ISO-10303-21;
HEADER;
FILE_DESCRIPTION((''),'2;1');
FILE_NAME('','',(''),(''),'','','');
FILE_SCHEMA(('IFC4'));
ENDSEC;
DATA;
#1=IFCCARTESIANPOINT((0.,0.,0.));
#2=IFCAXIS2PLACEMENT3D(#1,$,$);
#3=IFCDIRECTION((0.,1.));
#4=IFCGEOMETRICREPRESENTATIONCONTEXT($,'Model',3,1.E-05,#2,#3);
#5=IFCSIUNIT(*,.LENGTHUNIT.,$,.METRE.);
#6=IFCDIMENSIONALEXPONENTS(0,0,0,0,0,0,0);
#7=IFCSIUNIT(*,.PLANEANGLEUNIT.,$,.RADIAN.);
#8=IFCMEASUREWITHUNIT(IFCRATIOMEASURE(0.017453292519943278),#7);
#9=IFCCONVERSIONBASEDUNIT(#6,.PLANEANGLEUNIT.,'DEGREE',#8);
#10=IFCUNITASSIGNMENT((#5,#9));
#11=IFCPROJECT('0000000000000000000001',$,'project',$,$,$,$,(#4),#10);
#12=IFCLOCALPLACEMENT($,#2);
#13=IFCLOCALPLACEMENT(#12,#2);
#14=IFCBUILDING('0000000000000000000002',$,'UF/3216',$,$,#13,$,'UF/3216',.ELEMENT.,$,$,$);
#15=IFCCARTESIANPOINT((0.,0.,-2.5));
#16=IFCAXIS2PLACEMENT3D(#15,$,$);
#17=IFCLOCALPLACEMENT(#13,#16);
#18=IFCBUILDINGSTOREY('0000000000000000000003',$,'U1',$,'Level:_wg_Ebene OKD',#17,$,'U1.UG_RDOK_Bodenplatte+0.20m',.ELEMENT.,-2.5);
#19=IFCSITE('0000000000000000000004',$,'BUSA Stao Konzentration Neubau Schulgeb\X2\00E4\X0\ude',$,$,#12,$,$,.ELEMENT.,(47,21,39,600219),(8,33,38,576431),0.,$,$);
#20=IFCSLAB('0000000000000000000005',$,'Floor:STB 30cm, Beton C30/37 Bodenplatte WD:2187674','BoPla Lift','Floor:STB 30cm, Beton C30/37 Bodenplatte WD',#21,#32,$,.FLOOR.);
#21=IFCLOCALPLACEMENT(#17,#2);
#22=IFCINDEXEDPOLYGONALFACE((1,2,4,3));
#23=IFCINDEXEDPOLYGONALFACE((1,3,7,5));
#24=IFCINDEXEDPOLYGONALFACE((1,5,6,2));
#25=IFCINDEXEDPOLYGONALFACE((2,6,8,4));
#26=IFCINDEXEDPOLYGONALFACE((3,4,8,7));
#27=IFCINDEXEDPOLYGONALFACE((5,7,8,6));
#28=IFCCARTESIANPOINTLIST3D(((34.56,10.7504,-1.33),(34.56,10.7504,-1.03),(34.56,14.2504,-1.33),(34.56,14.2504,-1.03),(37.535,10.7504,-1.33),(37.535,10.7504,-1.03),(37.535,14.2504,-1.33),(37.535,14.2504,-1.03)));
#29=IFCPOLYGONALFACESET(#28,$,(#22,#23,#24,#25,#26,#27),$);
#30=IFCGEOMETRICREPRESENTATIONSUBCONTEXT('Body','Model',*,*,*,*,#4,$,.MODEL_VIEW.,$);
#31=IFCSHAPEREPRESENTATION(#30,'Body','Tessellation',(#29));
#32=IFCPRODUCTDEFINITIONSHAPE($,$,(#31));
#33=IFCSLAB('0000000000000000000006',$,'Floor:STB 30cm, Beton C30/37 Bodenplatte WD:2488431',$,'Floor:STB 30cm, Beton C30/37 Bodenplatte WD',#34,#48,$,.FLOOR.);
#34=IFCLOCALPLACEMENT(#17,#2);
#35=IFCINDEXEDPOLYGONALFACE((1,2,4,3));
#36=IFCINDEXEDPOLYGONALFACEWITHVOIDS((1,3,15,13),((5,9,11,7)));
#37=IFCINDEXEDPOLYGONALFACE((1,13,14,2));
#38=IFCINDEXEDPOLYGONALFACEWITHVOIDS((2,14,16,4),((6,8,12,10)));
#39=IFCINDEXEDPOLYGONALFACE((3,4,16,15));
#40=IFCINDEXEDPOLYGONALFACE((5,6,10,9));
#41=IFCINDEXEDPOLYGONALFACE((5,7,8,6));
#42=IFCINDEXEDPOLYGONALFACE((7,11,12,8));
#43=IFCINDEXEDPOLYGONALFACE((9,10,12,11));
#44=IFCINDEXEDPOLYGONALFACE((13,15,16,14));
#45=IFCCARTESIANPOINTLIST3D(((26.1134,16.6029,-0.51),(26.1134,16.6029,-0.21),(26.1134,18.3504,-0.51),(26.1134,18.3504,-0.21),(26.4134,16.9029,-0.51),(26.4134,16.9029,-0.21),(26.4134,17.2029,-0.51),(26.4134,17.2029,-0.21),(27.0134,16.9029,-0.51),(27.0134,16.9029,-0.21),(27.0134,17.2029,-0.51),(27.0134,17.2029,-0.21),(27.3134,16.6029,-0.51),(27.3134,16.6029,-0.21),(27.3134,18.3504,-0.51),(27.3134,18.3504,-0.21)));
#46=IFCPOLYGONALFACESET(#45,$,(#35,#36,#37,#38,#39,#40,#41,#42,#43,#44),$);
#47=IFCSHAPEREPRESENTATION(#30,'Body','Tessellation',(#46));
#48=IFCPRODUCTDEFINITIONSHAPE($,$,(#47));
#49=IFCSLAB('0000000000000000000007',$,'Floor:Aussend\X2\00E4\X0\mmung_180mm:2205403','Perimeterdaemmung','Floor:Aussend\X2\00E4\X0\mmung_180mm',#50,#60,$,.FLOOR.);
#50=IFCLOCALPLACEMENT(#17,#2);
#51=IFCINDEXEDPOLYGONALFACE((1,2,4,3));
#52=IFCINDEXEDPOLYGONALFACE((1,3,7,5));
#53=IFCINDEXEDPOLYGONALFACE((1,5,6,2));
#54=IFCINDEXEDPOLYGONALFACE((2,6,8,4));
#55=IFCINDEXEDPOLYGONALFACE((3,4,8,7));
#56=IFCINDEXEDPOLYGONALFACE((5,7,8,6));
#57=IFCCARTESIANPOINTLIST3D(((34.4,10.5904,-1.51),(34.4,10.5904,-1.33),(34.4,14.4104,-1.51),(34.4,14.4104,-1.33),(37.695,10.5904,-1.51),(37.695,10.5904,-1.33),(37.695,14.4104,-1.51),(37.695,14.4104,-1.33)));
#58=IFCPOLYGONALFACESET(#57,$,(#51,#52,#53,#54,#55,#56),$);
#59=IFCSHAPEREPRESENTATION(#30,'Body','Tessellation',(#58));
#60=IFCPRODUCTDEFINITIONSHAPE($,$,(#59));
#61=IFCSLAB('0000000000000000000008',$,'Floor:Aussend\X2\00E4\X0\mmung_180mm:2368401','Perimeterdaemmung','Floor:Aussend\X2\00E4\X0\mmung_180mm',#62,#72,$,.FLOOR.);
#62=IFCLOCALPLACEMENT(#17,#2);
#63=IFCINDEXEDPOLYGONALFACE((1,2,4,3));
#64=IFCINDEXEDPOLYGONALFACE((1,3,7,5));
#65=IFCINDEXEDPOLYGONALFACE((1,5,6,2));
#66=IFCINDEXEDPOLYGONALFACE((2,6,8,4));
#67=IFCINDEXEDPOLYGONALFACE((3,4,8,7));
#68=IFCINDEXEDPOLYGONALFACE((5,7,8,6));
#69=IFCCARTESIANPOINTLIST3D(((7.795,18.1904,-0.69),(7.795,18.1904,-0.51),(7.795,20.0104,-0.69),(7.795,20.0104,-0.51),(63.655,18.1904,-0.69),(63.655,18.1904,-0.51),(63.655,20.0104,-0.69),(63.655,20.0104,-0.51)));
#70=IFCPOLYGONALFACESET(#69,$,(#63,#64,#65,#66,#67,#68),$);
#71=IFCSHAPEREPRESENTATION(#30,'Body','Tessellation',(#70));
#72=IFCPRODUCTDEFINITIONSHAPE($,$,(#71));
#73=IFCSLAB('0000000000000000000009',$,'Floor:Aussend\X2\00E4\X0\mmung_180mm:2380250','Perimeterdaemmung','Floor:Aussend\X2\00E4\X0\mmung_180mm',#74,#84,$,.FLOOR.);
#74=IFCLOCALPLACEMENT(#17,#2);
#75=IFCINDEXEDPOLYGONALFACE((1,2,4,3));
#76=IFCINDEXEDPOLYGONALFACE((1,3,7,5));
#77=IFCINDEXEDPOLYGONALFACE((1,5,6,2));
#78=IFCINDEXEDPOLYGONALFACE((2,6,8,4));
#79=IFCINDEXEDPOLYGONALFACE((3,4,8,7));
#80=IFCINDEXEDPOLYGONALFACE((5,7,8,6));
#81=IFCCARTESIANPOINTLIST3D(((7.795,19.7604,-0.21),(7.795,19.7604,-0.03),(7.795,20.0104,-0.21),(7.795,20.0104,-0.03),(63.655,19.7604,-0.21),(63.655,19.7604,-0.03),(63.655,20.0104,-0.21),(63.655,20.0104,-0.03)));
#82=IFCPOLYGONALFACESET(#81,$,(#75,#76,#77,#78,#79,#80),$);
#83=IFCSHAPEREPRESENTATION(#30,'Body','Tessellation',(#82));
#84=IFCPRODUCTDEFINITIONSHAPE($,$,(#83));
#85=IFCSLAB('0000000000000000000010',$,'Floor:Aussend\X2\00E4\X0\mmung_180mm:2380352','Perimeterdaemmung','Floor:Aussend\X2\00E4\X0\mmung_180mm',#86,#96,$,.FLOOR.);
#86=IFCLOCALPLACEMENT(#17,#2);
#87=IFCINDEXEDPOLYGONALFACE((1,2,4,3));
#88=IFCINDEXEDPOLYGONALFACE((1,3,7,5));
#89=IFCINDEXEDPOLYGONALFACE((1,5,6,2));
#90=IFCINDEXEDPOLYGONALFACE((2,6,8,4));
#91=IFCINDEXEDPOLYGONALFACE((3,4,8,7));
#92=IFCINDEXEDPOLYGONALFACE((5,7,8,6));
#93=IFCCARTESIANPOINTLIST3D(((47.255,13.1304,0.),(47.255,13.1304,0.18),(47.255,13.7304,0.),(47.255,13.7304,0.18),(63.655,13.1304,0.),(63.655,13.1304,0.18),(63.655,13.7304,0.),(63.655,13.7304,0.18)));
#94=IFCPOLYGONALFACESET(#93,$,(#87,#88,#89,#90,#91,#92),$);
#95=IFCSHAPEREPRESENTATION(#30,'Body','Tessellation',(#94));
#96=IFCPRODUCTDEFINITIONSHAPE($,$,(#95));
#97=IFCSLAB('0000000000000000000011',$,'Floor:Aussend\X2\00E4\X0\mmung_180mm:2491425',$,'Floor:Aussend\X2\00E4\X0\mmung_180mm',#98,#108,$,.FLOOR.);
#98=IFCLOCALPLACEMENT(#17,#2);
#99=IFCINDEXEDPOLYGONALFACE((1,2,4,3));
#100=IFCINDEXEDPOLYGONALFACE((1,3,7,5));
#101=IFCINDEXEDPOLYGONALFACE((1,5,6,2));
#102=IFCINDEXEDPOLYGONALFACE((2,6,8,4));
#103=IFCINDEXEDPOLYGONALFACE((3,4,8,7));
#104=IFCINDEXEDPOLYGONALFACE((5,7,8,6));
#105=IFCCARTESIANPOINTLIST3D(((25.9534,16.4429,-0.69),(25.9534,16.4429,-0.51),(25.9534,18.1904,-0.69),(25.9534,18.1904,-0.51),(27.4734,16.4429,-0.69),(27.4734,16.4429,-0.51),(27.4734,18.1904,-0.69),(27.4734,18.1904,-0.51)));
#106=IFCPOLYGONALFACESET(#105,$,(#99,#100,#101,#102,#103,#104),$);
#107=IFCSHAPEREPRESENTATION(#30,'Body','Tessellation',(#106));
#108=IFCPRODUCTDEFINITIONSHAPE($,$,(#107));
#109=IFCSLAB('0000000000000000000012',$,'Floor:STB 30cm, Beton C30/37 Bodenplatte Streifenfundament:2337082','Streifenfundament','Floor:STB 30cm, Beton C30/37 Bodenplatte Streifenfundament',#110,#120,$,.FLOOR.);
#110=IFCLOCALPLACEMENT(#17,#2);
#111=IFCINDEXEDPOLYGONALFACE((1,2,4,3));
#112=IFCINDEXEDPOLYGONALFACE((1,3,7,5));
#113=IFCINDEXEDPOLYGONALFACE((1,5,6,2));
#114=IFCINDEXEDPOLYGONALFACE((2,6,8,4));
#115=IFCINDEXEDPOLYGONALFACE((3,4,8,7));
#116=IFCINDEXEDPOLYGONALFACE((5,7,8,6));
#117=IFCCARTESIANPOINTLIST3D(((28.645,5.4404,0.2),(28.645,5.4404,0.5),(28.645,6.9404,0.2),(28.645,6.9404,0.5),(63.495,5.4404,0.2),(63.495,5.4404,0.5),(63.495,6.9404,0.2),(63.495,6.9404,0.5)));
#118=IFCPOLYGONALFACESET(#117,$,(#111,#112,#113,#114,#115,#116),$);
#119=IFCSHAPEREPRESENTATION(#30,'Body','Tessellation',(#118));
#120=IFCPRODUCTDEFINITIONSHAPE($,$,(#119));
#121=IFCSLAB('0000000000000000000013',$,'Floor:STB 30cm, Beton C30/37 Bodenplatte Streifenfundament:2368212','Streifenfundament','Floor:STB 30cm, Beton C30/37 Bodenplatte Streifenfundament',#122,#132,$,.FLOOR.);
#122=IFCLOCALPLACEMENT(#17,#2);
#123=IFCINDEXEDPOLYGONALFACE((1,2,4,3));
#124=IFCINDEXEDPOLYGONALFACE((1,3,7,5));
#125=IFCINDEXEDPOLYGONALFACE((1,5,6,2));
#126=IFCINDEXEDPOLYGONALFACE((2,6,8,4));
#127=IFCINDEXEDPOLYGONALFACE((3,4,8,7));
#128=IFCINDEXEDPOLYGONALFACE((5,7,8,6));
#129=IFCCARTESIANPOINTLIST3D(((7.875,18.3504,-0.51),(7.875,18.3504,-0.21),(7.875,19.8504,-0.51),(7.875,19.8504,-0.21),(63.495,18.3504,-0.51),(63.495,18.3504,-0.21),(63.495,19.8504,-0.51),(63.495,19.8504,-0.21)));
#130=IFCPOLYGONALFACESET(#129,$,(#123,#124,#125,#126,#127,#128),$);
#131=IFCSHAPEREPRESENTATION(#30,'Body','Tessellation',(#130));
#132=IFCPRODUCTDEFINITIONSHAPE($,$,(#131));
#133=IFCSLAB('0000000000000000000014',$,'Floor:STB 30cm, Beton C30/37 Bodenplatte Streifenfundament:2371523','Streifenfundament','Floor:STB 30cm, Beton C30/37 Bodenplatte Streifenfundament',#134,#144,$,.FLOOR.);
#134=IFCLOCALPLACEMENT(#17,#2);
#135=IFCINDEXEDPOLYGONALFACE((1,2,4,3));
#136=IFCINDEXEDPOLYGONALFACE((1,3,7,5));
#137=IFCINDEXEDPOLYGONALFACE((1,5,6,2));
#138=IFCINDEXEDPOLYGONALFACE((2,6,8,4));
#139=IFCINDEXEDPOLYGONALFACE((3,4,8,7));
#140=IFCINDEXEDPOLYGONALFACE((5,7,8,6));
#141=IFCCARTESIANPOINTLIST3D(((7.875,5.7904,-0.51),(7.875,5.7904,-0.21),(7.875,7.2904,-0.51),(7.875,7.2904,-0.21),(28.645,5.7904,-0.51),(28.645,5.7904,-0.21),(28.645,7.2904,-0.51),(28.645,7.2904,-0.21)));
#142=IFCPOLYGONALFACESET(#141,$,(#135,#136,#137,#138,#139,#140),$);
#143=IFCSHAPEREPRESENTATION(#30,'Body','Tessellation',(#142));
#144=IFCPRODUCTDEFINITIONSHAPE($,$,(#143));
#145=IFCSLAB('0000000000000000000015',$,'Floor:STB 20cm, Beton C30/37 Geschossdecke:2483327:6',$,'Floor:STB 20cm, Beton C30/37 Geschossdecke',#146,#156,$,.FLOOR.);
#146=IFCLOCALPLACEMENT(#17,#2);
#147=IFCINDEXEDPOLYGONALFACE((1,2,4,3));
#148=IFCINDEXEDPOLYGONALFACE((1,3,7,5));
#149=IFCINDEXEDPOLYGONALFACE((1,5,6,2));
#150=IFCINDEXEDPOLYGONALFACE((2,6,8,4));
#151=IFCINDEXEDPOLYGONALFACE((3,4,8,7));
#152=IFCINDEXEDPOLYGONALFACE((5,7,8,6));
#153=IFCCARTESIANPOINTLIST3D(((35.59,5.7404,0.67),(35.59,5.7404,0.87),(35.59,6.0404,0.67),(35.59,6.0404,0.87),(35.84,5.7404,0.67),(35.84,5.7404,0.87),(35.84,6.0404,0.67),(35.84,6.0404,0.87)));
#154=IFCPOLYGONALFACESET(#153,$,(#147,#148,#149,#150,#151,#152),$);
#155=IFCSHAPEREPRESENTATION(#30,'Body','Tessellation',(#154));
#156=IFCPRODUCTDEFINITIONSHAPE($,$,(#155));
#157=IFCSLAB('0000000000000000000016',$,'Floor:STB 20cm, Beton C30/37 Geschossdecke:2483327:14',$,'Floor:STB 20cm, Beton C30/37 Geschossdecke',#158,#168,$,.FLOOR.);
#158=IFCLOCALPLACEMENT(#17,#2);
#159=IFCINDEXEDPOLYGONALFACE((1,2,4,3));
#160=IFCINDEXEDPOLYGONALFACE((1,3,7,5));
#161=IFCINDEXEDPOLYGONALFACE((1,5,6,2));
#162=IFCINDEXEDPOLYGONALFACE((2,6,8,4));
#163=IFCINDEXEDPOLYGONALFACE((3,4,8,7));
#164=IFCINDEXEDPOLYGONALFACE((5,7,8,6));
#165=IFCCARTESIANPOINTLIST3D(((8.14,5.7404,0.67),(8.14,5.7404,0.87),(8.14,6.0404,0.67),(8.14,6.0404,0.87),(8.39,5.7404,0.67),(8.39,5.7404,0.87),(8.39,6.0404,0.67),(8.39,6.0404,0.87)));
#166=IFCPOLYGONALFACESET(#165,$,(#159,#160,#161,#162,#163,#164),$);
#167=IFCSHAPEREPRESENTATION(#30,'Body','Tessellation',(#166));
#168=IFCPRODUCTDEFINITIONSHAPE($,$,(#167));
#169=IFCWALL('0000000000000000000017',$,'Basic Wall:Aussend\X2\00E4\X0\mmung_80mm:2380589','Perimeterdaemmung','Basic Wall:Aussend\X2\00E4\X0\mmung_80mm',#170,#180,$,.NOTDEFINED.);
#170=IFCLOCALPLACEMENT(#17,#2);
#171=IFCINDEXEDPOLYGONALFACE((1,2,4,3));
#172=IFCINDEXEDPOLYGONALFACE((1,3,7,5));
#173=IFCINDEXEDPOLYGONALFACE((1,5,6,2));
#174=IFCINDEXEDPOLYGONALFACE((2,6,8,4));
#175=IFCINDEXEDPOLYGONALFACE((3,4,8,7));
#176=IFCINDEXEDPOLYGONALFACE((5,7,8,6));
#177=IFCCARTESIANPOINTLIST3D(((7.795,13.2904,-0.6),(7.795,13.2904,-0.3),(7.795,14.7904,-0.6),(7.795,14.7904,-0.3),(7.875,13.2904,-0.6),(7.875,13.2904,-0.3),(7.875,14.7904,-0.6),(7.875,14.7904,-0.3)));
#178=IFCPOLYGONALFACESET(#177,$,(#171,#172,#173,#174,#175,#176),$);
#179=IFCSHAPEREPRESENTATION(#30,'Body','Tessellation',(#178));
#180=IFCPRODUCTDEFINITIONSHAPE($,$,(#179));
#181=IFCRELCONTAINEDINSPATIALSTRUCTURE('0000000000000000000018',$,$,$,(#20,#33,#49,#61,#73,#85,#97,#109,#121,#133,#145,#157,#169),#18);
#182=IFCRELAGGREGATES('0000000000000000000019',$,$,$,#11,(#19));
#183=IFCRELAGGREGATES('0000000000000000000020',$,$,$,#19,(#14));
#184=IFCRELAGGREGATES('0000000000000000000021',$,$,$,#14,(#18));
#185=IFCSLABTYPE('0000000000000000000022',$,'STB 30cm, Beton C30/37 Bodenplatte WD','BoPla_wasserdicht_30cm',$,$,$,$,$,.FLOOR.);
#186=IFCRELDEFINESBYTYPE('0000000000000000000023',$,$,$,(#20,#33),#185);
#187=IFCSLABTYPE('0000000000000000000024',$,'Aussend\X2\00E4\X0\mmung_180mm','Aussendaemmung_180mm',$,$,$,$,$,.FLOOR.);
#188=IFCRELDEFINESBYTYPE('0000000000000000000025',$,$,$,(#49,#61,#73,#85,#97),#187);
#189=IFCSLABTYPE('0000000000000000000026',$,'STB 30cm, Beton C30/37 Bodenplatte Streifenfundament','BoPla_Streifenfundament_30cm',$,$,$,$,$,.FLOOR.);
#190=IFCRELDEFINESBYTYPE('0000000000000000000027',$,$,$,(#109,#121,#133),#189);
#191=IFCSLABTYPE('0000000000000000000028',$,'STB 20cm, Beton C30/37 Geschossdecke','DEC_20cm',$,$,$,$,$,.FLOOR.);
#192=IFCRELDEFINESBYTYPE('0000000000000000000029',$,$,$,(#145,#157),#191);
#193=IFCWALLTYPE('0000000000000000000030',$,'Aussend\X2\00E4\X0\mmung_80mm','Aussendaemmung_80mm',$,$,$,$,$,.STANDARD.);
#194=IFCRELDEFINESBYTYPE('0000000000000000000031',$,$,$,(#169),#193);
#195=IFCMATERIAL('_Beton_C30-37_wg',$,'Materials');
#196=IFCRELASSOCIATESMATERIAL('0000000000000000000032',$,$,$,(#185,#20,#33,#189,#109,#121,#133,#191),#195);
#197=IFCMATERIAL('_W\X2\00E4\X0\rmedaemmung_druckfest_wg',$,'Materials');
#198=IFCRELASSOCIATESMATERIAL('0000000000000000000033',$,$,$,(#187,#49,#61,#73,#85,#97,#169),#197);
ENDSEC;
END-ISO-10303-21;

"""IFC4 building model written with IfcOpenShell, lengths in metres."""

from ifc_helpers import new_model, entity, si_unit, converted_unit, direction, frame, frame_2d, origin, place, context, subcontext, project, spatial, indexed_curve, rectangle, outline, extrude, material, type_object, element, save


model = new_model("IFC4")

# Units and contexts
model_context = context("Model", 3, precision=1e-05, world=origin(), true_north=direction((0.0, 1.0)))
body_context = subcontext(model_context, "Body", "Model", "MODEL_VIEW")
ifc_project = project(units=[si_unit("LENGTHUNIT", "METRE"), converted_unit("PLANEANGLEUNIT", "DEGREE", entity("IfcRatioMeasure", 0.017453292519943278), si_unit("PLANEANGLEUNIT", "RADIAN"), dimensions=[0, 0, 0, 0, 0, 0, 0])], contexts=[model_context])

# Site, building, storey
site_placement = place(None, origin())
site = spatial("IfcSite", under=ifc_project, at=site_placement, Name="BUSA Stao Konzentration Neubau Schulgebäude", CompositionType="ELEMENT", RefLatitude=(47, 21, 39, 600219), RefLongitude=(8, 33, 38, 576431), RefElevation=0.0)
building_placement = place(site_placement, origin())
building = spatial("IfcBuilding", under=site, at=building_placement, Name="UF/3216", LongName="UF/3216", CompositionType="ELEMENT")
storey_placement = place(building_placement, frame((0.0, 0.0, -2.5)))
storey = spatial("IfcBuildingStorey", under=building, at=storey_placement, Name="U1", ObjectType="Level:_wg_Ebene OKD", LongName="U1.UG_RDOK_Bodenplatte+0.20m", CompositionType="ELEMENT", Elevation=-2.5)

# Slabs
ifc_material_1 = material(Name="_Beton_C30-37_wg", Category="Materials")
slab_type_1 = type_object("IfcSlabType", Name="STB 30cm, Beton C30/37 Bodenplatte WD", Description="BoPla_wasserdicht_30cm", PredefinedType="FLOOR", material=ifc_material_1)
slab_1_placement = place(storey_placement, origin())
element("IfcSlab", 1, at=slab_1_placement, inside=storey, type_object=slab_type_1, material=ifc_material_1, Name="Floor:STB 30cm, Beton C30/37 Bodenplatte WD:2187674", Description="BoPla Lift", ObjectType="Floor:STB 30cm, Beton C30/37 Bodenplatte WD", PredefinedType="FLOOR", context=body_context, shape_type="SweptSolid", body=[
    extrude(outline(indexed_curve([(-1.75, -1.4875), (1.75, -1.4875), (1.75, 1.4875), (-1.75, 1.4875), (-1.75, -1.4875)], self_intersect=False)), frame((36.0475, 12.5004, -1.03), z_axis=(0.0, 0.0, -1.0), x_axis=(0.0, 1.0, 0.0)), (0.0, 0.0, 1.0), 0.3),
])
slab_2_placement = place(storey_placement, origin())
element("IfcSlab", 2, at=slab_2_placement, inside=storey, type_object=slab_type_1, material=ifc_material_1, Name="Floor:STB 30cm, Beton C30/37 Bodenplatte WD:2488431", ObjectType="Floor:STB 30cm, Beton C30/37 Bodenplatte WD", PredefinedType="FLOOR", context=body_context, shape_type="SweptSolid", body=[
    extrude(outline(indexed_curve([(-0.8737, -0.6), (0.8737, -0.6), (0.8737, 0.6), (-0.8737, 0.6), (-0.8737, -0.6)], self_intersect=False), holes=[indexed_curve([(0.2737, 0.3), (0.5737, 0.3), (0.5737, -0.3), (0.2737, -0.3), (0.2737, 0.3)], self_intersect=False)]), frame((26.7134, 17.4766, -0.51), z_axis=(0.0, 0.0, 1.0), x_axis=(0.0, -1.0, 0.0)), (0.0, 0.0, 1.0), 0.3),
])
ifc_material_2 = material(Name="_Wärmedaemmung_druckfest_wg", Category="Materials")
slab_type_2 = type_object("IfcSlabType", Name="Aussendämmung_180mm", Description="Aussendaemmung_180mm", PredefinedType="FLOOR", material=ifc_material_2)
slab_3_placement = place(storey_placement, origin())
element("IfcSlab", 3, at=slab_3_placement, inside=storey, type_object=slab_type_2, material=ifc_material_2, Name="Floor:Aussendämmung_180mm:2205403", Description="Perimeterdaemmung", ObjectType="Floor:Aussendämmung_180mm", PredefinedType="FLOOR", context=body_context, shape_type="SweptSolid", body=[
    extrude(outline(indexed_curve([(-1.91, -1.6475), (1.91, -1.6475), (1.91, 1.6475), (-1.91, 1.6475), (-1.91, -1.6475)], self_intersect=False)), frame((36.0475, 12.5004, -1.33), z_axis=(0.0, 0.0, -1.0), x_axis=(0.0, 1.0, 0.0)), (0.0, 0.0, 1.0), 0.18),
])
slab_4_placement = place(storey_placement, origin())
element("IfcSlab", 4, at=slab_4_placement, inside=storey, type_object=slab_type_2, material=ifc_material_2, Name="Floor:Aussendämmung_180mm:2368401", Description="Perimeterdaemmung", ObjectType="Floor:Aussendämmung_180mm", PredefinedType="FLOOR", context=body_context, shape_type="SweptSolid", body=[
    extrude(outline(indexed_curve([(-0.91, -27.93), (0.91, -27.93), (0.91, 27.93), (-0.91, 27.93), (-0.91, -27.93)], self_intersect=False)), frame((35.725, 19.1004, -0.51), z_axis=(0.0, 0.0, -1.0), x_axis=(0.0, 1.0, 0.0)), (0.0, 0.0, 1.0), 0.18),
])
slab_5_placement = place(storey_placement, origin())
element("IfcSlab", 5, at=slab_5_placement, inside=storey, type_object=slab_type_2, material=ifc_material_2, Name="Floor:Aussendämmung_180mm:2380250", Description="Perimeterdaemmung", ObjectType="Floor:Aussendämmung_180mm", PredefinedType="FLOOR", context=body_context, shape_type="SweptSolid", body=[
    extrude(outline(indexed_curve([(-0.125, -27.93), (0.125, -27.93), (0.125, 27.93), (-0.125, 27.93), (-0.125, -27.93)], self_intersect=False)), frame((35.725, 19.8854, -0.03), z_axis=(0.0, 0.0, -1.0), x_axis=(0.0, 1.0, 0.0)), (0.0, 0.0, 1.0), 0.18),
])
slab_6_placement = place(storey_placement, origin())
element("IfcSlab", 6, at=slab_6_placement, inside=storey, type_object=slab_type_2, material=ifc_material_2, Name="Floor:Aussendämmung_180mm:2380352", Description="Perimeterdaemmung", ObjectType="Floor:Aussendämmung_180mm", PredefinedType="FLOOR", context=body_context, shape_type="SweptSolid", body=[
    extrude(outline(indexed_curve([(-0.3, -8.2), (0.3, -8.2), (0.3, 8.2), (-0.3, 8.2), (-0.3, -8.2)], self_intersect=False)), frame((55.455, 13.4304, 0.18), z_axis=(0.0, 0.0, -1.0), x_axis=(0.0, 1.0, 0.0)), (0.0, 0.0, 1.0), 0.18),
])
slab_7_placement = place(storey_placement, origin())
element("IfcSlab", 7, at=slab_7_placement, inside=storey, type_object=slab_type_2, material=ifc_material_2, Name="Floor:Aussendämmung_180mm:2491425", ObjectType="Floor:Aussendämmung_180mm", PredefinedType="FLOOR", context=body_context, shape_type="SweptSolid", body=[
    extrude(outline(indexed_curve([(-0.8737, -0.76), (0.8737, -0.76), (0.8737, 0.76), (-0.8737, 0.76), (-0.8737, -0.76)], self_intersect=False)), frame((26.7134, 17.3166, -0.51), z_axis=(0.0, 0.0, -1.0), x_axis=(0.0, 1.0, 0.0)), (0.0, 0.0, 1.0), 0.18),
])
slab_type_3 = type_object("IfcSlabType", Name="STB 30cm, Beton C30/37 Bodenplatte Streifenfundament", Description="BoPla_Streifenfundament_30cm", PredefinedType="FLOOR", material=ifc_material_1)
slab_8_placement = place(storey_placement, origin())
element("IfcSlab", 8, at=slab_8_placement, inside=storey, type_object=slab_type_3, material=ifc_material_1, Name="Floor:STB 30cm, Beton C30/37 Bodenplatte Streifenfundament:2337082", Description="Streifenfundament", ObjectType="Floor:STB 30cm, Beton C30/37 Bodenplatte Streifenfundament", PredefinedType="FLOOR", context=body_context, shape_type="SweptSolid", body=[
    extrude(outline(indexed_curve([(-0.75, -17.425), (0.75, -17.425), (0.75, 17.425), (-0.75, 17.425), (-0.75, -17.425)], self_intersect=False)), frame((46.07, 6.1904, 0.5), z_axis=(0.0, 0.0, -1.0), x_axis=(0.0, 1.0, 0.0)), (0.0, 0.0, 1.0), 0.3),
])
slab_9_placement = place(storey_placement, origin())
element("IfcSlab", 9, at=slab_9_placement, inside=storey, type_object=slab_type_3, material=ifc_material_1, Name="Floor:STB 30cm, Beton C30/37 Bodenplatte Streifenfundament:2368212", Description="Streifenfundament", ObjectType="Floor:STB 30cm, Beton C30/37 Bodenplatte Streifenfundament", PredefinedType="FLOOR", context=body_context, shape_type="SweptSolid", body=[
    extrude(outline(indexed_curve([(-0.75, -27.81), (0.75, -27.81), (0.75, 27.81), (-0.75, 27.81), (-0.75, -27.81)], self_intersect=False)), frame((35.685, 19.1004, -0.21), z_axis=(0.0, 0.0, -1.0), x_axis=(0.0, 1.0, 0.0)), (0.0, 0.0, 1.0), 0.3),
])
slab_10_placement = place(storey_placement, origin())
element("IfcSlab", 10, at=slab_10_placement, inside=storey, type_object=slab_type_3, material=ifc_material_1, Name="Floor:STB 30cm, Beton C30/37 Bodenplatte Streifenfundament:2371523", Description="Streifenfundament", ObjectType="Floor:STB 30cm, Beton C30/37 Bodenplatte Streifenfundament", PredefinedType="FLOOR", context=body_context, shape_type="SweptSolid", body=[
    extrude(outline(indexed_curve([(-0.75, -10.385), (0.75, -10.385), (0.75, 10.385), (-0.75, 10.385), (-0.75, -10.385)], self_intersect=False)), frame((18.26, 6.5404, -0.21), z_axis=(0.0, 0.0, -1.0), x_axis=(0.0, 1.0, 0.0)), (0.0, 0.0, 1.0), 0.3),
])
slab_type_4 = type_object("IfcSlabType", Name="STB 20cm, Beton C30/37 Geschossdecke", Description="DEC_20cm", PredefinedType="FLOOR", material=ifc_material_1)
slab_11_placement = place(storey_placement, frame((8.14, 5.7404, 0.67)))
element("IfcSlab", 11, at=slab_11_placement, inside=storey, type_object=slab_type_4, Name="Floor:STB 20cm, Beton C30/37 Geschossdecke:2483327:6", ObjectType="Floor:STB 20cm, Beton C30/37 Geschossdecke", PredefinedType="FLOOR", context=body_context, shape_type="SweptSolid", body=[
    extrude(rectangle(XDim=0.3, YDim=0.25, at=frame_2d((0.0, 0.0), x_axis=(0.0, -1.0))), frame((27.575, 0.15, 0.2), z_axis=(0.0, 0.0, -1.0), x_axis=(-1.0, 0.0, 0.0)), (0.0, 0.0, 1.0), 0.2),
])
slab_12_placement = place(storey_placement, frame((8.14, 5.7404, 0.67)))
element("IfcSlab", 12, at=slab_12_placement, inside=storey, type_object=slab_type_4, Name="Floor:STB 20cm, Beton C30/37 Geschossdecke:2483327:14", ObjectType="Floor:STB 20cm, Beton C30/37 Geschossdecke", PredefinedType="FLOOR", context=body_context, shape_type="SweptSolid", body=[
    extrude(rectangle(XDim=0.3, YDim=0.25, at=frame_2d((27.45, 0.0), x_axis=(0.0, -1.0))), frame((27.575, 0.15, 0.2), z_axis=(0.0, 0.0, -1.0), x_axis=(-1.0, 0.0, 0.0)), (0.0, 0.0, 1.0), 0.2),
])

# Wall
wall_type = type_object("IfcWallType", Name="Aussendämmung_80mm", Description="Aussendaemmung_80mm", PredefinedType="STANDARD")
wall_placement = place(storey_placement, frame((7.835, 13.2904, -0.6), z_axis=(0.0, 0.0, 1.0), x_axis=(0.0, 1.0, 0.0)))
element("IfcWall", 13, at=wall_placement, inside=storey, type_object=wall_type, material=ifc_material_2, Name="Basic Wall:Aussendämmung_80mm:2380589", Description="Perimeterdaemmung", ObjectType="Basic Wall:Aussendämmung_80mm", PredefinedType="NOTDEFINED", context=body_context, shape_type="SweptSolid", body=[
    extrude(outline(indexed_curve([(1.5, 0.04), (0.0, 0.04), (0.0, -0.04), (1.5, -0.04), (1.5, 0.04)], self_intersect=False)), origin(), (0.0, 0.0, 1.0), 0.3),
])

save(model, "model.ifc")
